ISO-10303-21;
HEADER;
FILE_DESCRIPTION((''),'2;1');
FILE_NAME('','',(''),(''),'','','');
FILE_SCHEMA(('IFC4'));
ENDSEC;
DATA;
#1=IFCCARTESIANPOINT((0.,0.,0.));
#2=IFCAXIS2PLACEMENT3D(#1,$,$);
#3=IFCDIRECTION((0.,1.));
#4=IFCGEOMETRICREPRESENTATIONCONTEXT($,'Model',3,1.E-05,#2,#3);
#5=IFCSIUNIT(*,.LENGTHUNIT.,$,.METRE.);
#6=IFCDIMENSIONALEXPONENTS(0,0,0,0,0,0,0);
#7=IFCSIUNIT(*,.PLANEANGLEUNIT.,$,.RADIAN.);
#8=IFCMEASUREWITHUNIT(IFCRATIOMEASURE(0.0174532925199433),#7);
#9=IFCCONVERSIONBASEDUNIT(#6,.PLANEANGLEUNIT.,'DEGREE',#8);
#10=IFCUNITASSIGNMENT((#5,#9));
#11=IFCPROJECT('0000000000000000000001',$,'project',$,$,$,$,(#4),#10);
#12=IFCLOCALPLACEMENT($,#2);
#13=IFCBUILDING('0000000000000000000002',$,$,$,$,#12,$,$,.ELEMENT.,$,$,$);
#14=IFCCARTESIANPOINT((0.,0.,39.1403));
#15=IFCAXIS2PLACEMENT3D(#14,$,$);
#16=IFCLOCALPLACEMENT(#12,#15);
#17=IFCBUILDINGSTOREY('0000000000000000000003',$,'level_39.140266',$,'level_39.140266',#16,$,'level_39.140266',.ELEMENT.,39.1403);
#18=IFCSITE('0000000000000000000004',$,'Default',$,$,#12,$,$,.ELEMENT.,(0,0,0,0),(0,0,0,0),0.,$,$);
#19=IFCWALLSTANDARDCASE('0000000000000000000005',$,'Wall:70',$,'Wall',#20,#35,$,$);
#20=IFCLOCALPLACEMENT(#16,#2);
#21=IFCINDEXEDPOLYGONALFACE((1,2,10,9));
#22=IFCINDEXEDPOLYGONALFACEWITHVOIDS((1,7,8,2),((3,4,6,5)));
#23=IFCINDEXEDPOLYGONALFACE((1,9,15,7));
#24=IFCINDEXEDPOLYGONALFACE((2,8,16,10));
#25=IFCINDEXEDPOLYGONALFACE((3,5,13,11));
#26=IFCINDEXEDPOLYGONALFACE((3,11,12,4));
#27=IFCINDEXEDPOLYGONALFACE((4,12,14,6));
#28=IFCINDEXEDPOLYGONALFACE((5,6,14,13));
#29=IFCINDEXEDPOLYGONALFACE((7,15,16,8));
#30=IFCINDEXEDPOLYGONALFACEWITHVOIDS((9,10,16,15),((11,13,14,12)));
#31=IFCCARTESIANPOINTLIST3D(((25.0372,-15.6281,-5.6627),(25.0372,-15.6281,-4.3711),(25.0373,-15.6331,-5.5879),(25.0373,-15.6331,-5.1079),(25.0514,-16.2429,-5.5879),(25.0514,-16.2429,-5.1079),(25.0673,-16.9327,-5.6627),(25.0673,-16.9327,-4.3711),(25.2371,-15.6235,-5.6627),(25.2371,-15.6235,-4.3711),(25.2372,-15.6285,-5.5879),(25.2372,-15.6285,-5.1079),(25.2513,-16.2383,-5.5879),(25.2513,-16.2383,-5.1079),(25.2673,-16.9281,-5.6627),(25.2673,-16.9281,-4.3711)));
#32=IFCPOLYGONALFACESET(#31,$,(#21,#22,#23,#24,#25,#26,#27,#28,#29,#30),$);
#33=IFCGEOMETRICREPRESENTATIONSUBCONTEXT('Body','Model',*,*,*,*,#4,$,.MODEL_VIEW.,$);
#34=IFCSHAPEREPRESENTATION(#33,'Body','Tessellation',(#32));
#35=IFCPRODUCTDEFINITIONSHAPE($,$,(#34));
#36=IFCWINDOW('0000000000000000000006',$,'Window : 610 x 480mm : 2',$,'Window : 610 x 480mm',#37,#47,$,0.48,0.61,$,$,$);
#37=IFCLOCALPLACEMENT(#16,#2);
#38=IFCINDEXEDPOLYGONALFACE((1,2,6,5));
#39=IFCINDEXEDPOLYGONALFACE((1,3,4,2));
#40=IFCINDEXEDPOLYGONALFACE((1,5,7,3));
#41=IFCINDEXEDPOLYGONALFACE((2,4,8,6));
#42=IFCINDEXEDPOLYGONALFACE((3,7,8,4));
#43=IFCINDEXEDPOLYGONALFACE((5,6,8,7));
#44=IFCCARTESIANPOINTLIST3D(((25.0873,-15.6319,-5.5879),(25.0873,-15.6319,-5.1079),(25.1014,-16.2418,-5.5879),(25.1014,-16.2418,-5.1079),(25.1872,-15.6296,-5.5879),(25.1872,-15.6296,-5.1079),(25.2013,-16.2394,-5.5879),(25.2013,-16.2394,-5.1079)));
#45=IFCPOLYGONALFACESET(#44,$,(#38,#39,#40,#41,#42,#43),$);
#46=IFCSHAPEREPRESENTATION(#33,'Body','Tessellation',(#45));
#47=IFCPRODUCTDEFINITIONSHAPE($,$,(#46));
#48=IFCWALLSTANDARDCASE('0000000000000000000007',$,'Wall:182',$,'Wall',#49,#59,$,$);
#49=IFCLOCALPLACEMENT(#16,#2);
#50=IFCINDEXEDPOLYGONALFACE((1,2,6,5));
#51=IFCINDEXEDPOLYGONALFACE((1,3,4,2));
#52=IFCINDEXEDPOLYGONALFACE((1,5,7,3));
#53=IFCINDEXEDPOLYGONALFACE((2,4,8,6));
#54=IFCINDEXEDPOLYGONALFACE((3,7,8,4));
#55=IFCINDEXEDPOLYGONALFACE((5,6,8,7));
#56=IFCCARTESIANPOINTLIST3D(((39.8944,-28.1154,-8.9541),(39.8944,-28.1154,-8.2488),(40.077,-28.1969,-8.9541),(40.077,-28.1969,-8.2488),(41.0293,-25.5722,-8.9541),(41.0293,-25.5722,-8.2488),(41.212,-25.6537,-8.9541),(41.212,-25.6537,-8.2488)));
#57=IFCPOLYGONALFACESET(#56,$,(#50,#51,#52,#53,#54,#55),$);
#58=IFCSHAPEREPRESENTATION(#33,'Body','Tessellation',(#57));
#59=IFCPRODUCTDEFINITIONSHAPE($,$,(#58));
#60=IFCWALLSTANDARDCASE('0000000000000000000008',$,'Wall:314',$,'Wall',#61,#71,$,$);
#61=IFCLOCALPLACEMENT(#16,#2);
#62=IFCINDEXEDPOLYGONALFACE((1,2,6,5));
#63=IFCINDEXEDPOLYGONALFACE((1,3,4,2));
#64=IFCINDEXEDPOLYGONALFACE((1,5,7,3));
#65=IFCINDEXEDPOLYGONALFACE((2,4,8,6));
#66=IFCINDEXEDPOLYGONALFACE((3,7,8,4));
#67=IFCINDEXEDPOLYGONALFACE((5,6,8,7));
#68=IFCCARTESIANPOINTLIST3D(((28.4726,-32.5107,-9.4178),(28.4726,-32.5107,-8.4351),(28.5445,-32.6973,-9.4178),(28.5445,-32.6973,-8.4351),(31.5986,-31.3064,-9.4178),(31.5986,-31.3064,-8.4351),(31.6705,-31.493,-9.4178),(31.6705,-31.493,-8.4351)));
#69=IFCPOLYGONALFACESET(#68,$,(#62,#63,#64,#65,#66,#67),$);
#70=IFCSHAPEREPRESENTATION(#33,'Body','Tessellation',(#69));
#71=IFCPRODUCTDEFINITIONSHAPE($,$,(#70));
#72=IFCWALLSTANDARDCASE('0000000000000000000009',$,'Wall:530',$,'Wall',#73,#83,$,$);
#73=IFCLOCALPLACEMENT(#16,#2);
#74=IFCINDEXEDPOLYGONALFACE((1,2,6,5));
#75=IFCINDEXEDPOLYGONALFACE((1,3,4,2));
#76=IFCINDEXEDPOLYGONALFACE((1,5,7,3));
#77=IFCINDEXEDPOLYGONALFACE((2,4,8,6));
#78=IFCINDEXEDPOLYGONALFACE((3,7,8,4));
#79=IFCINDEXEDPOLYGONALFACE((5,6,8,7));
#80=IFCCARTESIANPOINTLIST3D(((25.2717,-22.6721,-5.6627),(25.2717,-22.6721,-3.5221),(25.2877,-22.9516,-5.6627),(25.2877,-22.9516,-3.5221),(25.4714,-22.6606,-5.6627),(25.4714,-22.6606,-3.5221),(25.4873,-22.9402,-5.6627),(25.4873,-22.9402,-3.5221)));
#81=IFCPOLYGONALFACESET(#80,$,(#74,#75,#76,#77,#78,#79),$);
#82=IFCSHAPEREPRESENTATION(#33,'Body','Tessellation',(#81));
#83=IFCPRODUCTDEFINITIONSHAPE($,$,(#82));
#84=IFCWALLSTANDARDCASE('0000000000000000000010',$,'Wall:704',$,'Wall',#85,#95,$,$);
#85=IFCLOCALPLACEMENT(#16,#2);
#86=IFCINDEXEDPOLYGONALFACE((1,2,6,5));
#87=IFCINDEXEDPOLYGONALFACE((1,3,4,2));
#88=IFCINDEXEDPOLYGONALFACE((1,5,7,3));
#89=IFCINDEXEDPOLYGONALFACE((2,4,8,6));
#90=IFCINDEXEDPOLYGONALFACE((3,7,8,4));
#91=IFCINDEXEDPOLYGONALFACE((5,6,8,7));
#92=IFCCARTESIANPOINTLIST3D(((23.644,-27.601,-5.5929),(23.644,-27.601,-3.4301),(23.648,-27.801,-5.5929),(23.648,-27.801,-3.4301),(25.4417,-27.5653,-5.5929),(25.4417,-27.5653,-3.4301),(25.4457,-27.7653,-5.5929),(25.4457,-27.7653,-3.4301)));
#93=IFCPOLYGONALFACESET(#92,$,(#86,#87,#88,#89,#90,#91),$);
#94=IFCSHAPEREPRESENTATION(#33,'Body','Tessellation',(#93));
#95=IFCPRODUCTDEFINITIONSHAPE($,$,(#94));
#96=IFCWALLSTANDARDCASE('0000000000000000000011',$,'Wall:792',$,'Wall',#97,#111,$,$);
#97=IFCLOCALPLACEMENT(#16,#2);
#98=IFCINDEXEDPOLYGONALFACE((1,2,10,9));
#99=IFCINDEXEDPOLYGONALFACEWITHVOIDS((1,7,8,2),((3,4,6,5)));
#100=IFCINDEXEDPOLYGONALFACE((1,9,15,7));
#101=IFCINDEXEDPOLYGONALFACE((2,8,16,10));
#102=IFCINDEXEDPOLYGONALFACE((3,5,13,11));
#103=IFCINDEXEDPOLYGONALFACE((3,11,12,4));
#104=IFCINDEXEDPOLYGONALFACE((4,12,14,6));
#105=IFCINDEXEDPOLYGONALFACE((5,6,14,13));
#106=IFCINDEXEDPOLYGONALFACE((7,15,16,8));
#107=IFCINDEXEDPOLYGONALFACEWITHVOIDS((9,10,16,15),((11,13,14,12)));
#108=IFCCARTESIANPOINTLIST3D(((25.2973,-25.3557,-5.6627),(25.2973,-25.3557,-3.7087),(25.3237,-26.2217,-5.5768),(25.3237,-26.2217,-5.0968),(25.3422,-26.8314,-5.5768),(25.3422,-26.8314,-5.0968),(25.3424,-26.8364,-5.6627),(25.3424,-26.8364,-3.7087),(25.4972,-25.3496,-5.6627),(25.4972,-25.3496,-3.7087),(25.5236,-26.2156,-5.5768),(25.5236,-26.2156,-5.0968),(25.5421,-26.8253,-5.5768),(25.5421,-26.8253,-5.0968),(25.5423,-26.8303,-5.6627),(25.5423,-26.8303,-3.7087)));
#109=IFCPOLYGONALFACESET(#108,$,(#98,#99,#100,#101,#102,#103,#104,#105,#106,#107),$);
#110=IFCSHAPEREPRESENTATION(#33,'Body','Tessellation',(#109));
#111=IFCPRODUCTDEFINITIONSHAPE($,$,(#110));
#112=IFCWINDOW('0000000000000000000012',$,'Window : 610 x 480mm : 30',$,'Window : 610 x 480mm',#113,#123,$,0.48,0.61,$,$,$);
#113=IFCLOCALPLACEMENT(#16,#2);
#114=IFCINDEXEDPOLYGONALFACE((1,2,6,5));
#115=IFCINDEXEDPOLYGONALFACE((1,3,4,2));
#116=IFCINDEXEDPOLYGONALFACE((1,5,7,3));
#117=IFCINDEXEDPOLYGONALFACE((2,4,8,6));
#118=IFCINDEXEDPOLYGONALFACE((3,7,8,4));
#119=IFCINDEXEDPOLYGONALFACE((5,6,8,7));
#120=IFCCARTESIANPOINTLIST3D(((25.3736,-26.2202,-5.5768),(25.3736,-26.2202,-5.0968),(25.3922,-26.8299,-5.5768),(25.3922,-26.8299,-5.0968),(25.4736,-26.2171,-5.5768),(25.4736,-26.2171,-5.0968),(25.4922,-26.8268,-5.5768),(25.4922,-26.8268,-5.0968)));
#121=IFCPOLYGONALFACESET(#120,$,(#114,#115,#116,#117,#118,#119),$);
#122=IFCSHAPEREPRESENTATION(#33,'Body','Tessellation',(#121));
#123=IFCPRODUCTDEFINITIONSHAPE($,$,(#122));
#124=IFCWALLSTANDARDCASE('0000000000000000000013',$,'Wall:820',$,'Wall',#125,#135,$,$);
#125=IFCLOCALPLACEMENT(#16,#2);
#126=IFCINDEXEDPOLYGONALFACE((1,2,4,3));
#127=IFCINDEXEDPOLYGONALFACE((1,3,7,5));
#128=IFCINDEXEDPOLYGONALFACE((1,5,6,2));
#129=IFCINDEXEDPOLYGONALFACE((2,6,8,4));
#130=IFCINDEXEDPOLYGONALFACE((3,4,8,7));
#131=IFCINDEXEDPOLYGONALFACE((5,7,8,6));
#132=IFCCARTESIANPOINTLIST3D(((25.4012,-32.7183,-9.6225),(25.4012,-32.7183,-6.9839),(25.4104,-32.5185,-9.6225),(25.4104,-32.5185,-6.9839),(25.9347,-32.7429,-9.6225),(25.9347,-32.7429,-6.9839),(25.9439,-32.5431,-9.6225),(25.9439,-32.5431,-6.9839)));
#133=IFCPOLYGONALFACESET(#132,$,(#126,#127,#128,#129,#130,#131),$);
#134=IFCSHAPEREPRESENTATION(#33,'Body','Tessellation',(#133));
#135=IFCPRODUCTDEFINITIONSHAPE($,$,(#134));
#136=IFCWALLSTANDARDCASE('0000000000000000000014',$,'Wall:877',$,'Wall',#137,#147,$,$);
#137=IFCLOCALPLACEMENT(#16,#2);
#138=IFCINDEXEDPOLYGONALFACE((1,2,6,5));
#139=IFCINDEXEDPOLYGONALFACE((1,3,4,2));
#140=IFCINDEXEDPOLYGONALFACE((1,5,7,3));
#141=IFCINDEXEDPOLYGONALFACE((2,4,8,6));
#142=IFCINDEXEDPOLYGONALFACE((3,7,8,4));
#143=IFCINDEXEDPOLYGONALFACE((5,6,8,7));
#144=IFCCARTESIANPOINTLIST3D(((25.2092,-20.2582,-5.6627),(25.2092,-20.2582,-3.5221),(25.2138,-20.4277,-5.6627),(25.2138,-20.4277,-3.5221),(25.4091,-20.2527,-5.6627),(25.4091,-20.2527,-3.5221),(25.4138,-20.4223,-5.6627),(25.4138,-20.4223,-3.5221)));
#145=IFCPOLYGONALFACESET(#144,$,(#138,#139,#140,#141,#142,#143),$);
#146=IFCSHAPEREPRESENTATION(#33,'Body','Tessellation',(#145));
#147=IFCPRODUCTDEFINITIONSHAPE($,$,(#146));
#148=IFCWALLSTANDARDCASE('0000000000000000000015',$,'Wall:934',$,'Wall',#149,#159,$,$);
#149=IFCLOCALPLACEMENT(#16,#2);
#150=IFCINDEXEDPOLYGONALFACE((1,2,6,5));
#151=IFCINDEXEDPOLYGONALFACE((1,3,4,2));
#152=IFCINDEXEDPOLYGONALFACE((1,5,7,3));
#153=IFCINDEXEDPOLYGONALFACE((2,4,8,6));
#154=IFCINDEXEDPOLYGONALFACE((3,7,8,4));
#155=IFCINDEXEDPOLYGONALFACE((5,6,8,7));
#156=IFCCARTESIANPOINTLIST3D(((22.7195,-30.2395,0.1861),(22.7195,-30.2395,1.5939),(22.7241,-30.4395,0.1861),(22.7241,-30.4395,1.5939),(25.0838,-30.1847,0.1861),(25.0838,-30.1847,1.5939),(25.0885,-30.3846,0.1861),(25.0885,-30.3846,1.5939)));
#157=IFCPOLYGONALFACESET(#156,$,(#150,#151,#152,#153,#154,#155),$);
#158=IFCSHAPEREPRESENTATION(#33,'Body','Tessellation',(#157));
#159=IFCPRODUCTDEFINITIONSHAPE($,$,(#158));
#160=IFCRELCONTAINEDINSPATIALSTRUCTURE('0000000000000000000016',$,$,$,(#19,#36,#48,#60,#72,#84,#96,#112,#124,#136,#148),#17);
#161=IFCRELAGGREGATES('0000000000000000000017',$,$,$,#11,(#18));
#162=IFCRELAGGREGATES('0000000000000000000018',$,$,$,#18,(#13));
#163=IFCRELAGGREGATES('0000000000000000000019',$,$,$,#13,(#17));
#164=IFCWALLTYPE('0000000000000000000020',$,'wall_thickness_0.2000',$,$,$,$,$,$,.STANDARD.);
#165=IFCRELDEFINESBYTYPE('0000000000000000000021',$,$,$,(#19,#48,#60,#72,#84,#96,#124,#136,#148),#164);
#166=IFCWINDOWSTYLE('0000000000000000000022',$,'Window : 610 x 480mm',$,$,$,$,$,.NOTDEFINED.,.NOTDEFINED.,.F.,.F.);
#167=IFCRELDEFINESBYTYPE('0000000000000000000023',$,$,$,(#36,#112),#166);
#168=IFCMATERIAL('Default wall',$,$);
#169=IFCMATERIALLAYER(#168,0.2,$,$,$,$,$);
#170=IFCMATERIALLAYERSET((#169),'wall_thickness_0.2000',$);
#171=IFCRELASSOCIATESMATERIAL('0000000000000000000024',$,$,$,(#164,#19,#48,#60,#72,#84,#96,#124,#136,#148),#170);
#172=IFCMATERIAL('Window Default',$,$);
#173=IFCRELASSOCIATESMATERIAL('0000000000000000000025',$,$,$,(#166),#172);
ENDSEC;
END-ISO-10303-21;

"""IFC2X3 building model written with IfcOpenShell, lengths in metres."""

from ifc_helpers import new_model, entity, si_unit, converted_unit, direction, frame, frame_2d, origin, origin_2d_with_axis, place, context, subcontext, project, spatial, polyline, rectangle, outline, extrude, source, transform, mapped, material, layer, layer_set, layer_usage, type_object, type_shapes, element, fill, save


model = new_model("IFC2X3")

# Units and contexts
model_context = context("Model", 3, precision=1e-05, world=origin(), true_north=direction((0.0, 1.0)))
body_context = subcontext(model_context, "Body", "Model", "MODEL_VIEW")
ifc_project = project(units=[si_unit("LENGTHUNIT", "METRE"), converted_unit("PLANEANGLEUNIT", "DEGREE", entity("IfcRatioMeasure", 0.0174532925199433), si_unit("PLANEANGLEUNIT", "RADIAN"), dimensions=[0, 0, 0, 0, 0, 0, 0])], contexts=[model_context])

# Site, building, storey
placement_1 = place(None, origin())
site = spatial("IfcSite", under=ifc_project, at=placement_1, Name="Default", CompositionType="ELEMENT", RefLatitude=(0, 0, 0, 0), RefLongitude=(0, 0, 0, 0), RefElevation=0.0)
building = spatial("IfcBuilding", under=site, at=placement_1, CompositionType="ELEMENT")
storey_placement = place(placement_1, frame((0.0, 0.0, 39.1403)))
storey = spatial("IfcBuildingStorey", under=building, at=storey_placement, Name="level_39.140266", ObjectType="level_39.140266", LongName="level_39.140266", CompositionType="ELEMENT", Elevation=39.1403)

# Wall, opening, window
ifc_material_1 = material(Name="Default wall")
ifc_layer = layer(ifc_material_1, 0.2)
ifc_layer_set = layer_set([ifc_layer], Name="wall_thickness_0.2000")
ifc_layer_usage = layer_usage(ifc_layer_set, "AXIS2", "POSITIVE", -0.1)
wall_type = type_object("IfcWallType", Name="wall_thickness_0.2000", PredefinedType="STANDARD", material=ifc_layer_set)
placement_2 = place(placement_1, frame((0.0, 0.0, 33.4776)))
wall_1_placement = place(placement_2, frame((25.1673, -16.9304, 0.0), z_axis=(0.0, 0.0, 1.0), x_axis=(-0.023107, 0.999733, 0.0)))
wall_1 = element("IfcWallStandardCase", 1, at=wall_1_placement, inside=storey, type_object=wall_type, material=ifc_layer_usage, Name="Wall:70", ObjectType="Wall", context=body_context, shape_type="SweptSolid", body=[
    extrude(outline(polyline([(1.305, -0.1), (1.305, 0.1), (0.0, 0.1), (0.0, -0.1), (1.305, -0.1)])), origin(), (0.0, 0.0, 1.0), 1.2917),
])
opening_1_placement = place(wall_1_placement, frame((0.69, -0.1, 0.0749)))
opening_1 = element("IfcOpeningElement", 2, at=opening_1_placement, cuts=wall_1, ObjectType="Opening", context=body_context, shape_type="SweptSolid", body=[
    extrude(rectangle(XDim=0.61, YDim=0.48, at=frame_2d((0.24, 0.305), x_axis=(0.0, 1.0))), frame((0.0, 0.0, 0.0), z_axis=(0.0, 1.0, 0.0), x_axis=(0.0, 0.0, 1.0)), (0.0, 0.0, 1.0), 0.2),
])
ifc_material_2 = material(Name="Window Default")
window_style_1 = type_object("IfcWindowStyle", Name="Window : 610 x 480mm", ConstructionType="NOTDEFINED", OperationType="NOTDEFINED", ParameterTakesPrecedence=False, Sizeable=False, material=ifc_material_2)
shared_shape_1 = source(origin(), body_context, "Body", "SweptSolid", [
    extrude(rectangle(XDim=0.1, YDim=0.61, at=origin_2d_with_axis()), frame((0.305, 0.1, 0.0), z_axis=(0.0, 0.0, 1.0), x_axis=(0.0, 1.0, 0.0)), (0.0, 0.0, 1.0), 0.48),
])
type_shapes(window_style_1, [shared_shape_1])
window_1_placement = place(opening_1_placement, origin())
window_1 = element("IfcWindow", 3, at=window_1_placement, inside=storey, type_object=window_style_1, Name="Window : 610 x 480mm : 2", ObjectType="Window : 610 x 480mm", OverallHeight=0.48, OverallWidth=0.61, context=body_context, shape_type="MappedRepresentation", body=[
    mapped(shared_shape_1, transform((0.0, 0.0, 0.0), scale=1.0)),
])
fill(opening_1, window_1)

# Walls
placement_3 = place(placement_1, frame((0.0, 0.0, 30.1862)))
wall_2_placement = place(placement_3, frame((39.9857, -28.1562, 0.0), z_axis=(0.0, 0.0, 1.0), x_axis=(0.407516, 0.913198, 0.0)))
element("IfcWallStandardCase", 4, at=wall_2_placement, inside=storey, type_object=wall_type, material=ifc_layer_usage, Name="Wall:182", ObjectType="Wall", context=body_context, shape_type="SweptSolid", body=[
    extrude(outline(polyline([(2.785, -0.1), (2.785, 0.1), (0.0, 0.1), (0.0, -0.1), (2.785, -0.1)])), origin(), (0.0, 0.0, 1.0), 0.7053),
])
placement_4 = place(placement_1, frame((0.0, 0.0, 29.7225)))
wall_3_placement = place(placement_4, frame((28.5085, -32.604, 0.0), z_axis=(0.0, 0.0, 1.0), x_axis=(0.933147, 0.359495, 0.0)))
element("IfcWallStandardCase", 5, at=wall_3_placement, inside=storey, type_object=wall_type, material=ifc_layer_usage, Name="Wall:314", ObjectType="Wall", context=body_context, shape_type="SweptSolid", body=[
    extrude(outline(polyline([(3.35, -0.1), (3.35, 0.1), (0.0, 0.1), (0.0, -0.1), (3.35, -0.1)])), origin(), (0.0, 0.0, 1.0), 0.9827),
])
placement_5 = place(placement_1, frame((0.0, 0.0, 33.4776)))
wall_4_placement = place(placement_5, frame((25.3715, -22.6664, 0.0), z_axis=(0.0, 0.0, 1.0), x_axis=(0.057111, -0.998368, 0.0)))
element("IfcWallStandardCase", 6, at=wall_4_placement, inside=storey, type_object=wall_type, material=ifc_layer_usage, Name="Wall:530", ObjectType="Wall", context=body_context, shape_type="SweptSolid", body=[
    extrude(outline(polyline([(0.28, -0.1), (0.28, 0.1), (0.0, 0.1), (0.0, -0.1), (0.28, -0.1)])), origin(), (0.0, 0.0, 1.0), 2.1406),
])
placement_6 = place(placement_1, frame((0.0, 0.0, 33.5474)))
wall_5_placement = place(placement_6, frame((25.4437, -27.6653, 0.0), z_axis=(0.0, 0.0, 1.0), x_axis=(-0.999803, -0.019852, 0.0)))
element("IfcWallStandardCase", 7, at=wall_5_placement, inside=storey, type_object=wall_type, material=ifc_layer_usage, Name="Wall:704", ObjectType="Wall", context=body_context, shape_type="SweptSolid", body=[
    extrude(outline(polyline([(1.798, -0.1), (1.798, 0.1), (0.0, 0.1), (0.0, -0.1), (1.798, -0.1)])), origin(), (0.0, 0.0, 1.0), 2.1628),
])

# Wall, opening, window
placement_7 = place(placement_1, frame((0.0, 0.0, 33.4776)))
wall_6_placement = place(placement_7, frame((25.4423, -26.8333, 0.0), z_axis=(0.0, 0.0, 1.0), x_axis=(-0.030465, 0.999536, 0.0)))
wall_6 = element("IfcWallStandardCase", 8, at=wall_6_placement, inside=storey, type_object=wall_type, material=ifc_layer_usage, Name="Wall:792", ObjectType="Wall", context=body_context, shape_type="SweptSolid", body=[
    extrude(outline(polyline([(1.4814, -0.1), (1.4814, 0.1), (0.0, 0.1), (0.0, -0.1), (1.4814, -0.1)])), origin(), (0.0, 0.0, 1.0), 1.9541),
])
opening_2_placement = place(wall_6_placement, frame((0.005, -0.1, 0.0859)))
opening_2 = element("IfcOpeningElement", 9, at=opening_2_placement, cuts=wall_6, ObjectType="Opening", context=body_context, shape_type="SweptSolid", body=[
    extrude(rectangle(XDim=0.61, YDim=0.48, at=frame_2d((0.24, 0.305), x_axis=(0.0, 1.0))), frame((0.0, 0.0, 0.0), z_axis=(0.0, 1.0, 0.0), x_axis=(0.0, 0.0, 1.0)), (0.0, 0.0, 1.0), 0.2),
])
window_2_placement = place(opening_2_placement, origin())
window_2 = element("IfcWindow", 10, at=window_2_placement, inside=storey, type_object=window_style_1, Name="Window : 610 x 480mm : 30", ObjectType="Window : 610 x 480mm", OverallHeight=0.48, OverallWidth=0.61, context=body_context, shape_type="MappedRepresentation", body=[
    mapped(shared_shape_1, transform((0.0, 0.0, 0.0), scale=1.0)),
])
fill(opening_2, window_2)

# Walls
placement_8 = place(placement_1, frame((0.0, 0.0, 29.5178)))
wall_7_placement = place(placement_8, frame((25.9393, -32.643, 0.0), z_axis=(0.0, 0.0, 1.0), x_axis=(-0.998935, 0.046147, 0.0)))
element("IfcWallStandardCase", 11, at=wall_7_placement, inside=storey, type_object=wall_type, material=ifc_layer_usage, Name="Wall:820", ObjectType="Wall", context=body_context, shape_type="SweptSolid", body=[
    extrude(outline(polyline([(0.5341, -0.1), (0.5341, 0.1), (0.0, 0.1), (0.0, -0.1), (0.5341, -0.1)])), origin(), (0.0, 0.0, 1.0), 2.6386),
])
placement_9 = place(placement_1, frame((0.0, 0.0, 33.4776)))
wall_8_placement = place(placement_9, frame((25.3092, -20.2554, 0.0), z_axis=(0.0, 0.0, 1.0), x_axis=(0.027204, -0.99963, 0.0)))
element("IfcWallStandardCase", 12, at=wall_8_placement, inside=storey, type_object=wall_type, material=ifc_layer_usage, Name="Wall:877", ObjectType="Wall", context=body_context, shape_type="SweptSolid", body=[
    extrude(outline(polyline([(0.1696, -0.1), (0.1696, 0.1), (0.0, 0.1), (0.0, -0.1), (0.1696, -0.1)])), origin(), (0.0, 0.0, 1.0), 2.1406),
])
placement_10 = place(placement_1, frame((0.0, 0.0, 39.3264)))
wall_9_placement = place(placement_10, frame((22.7218, -30.3395, 0.0), z_axis=(0.0, 0.0, 1.0), x_axis=(0.999731, 0.023202, 0.0)))
element("IfcWallStandardCase", 13, at=wall_9_placement, inside=storey, type_object=wall_type, material=ifc_layer_usage, Name="Wall:934", ObjectType="Wall", context=body_context, shape_type="SweptSolid", body=[
    extrude(outline(polyline([(2.365, -0.1), (2.365, 0.1), (0.0, 0.1), (0.0, -0.1), (2.365, -0.1)])), origin(), (0.0, 0.0, 1.0), 1.4078),
])

save(model, "model.ifc")
